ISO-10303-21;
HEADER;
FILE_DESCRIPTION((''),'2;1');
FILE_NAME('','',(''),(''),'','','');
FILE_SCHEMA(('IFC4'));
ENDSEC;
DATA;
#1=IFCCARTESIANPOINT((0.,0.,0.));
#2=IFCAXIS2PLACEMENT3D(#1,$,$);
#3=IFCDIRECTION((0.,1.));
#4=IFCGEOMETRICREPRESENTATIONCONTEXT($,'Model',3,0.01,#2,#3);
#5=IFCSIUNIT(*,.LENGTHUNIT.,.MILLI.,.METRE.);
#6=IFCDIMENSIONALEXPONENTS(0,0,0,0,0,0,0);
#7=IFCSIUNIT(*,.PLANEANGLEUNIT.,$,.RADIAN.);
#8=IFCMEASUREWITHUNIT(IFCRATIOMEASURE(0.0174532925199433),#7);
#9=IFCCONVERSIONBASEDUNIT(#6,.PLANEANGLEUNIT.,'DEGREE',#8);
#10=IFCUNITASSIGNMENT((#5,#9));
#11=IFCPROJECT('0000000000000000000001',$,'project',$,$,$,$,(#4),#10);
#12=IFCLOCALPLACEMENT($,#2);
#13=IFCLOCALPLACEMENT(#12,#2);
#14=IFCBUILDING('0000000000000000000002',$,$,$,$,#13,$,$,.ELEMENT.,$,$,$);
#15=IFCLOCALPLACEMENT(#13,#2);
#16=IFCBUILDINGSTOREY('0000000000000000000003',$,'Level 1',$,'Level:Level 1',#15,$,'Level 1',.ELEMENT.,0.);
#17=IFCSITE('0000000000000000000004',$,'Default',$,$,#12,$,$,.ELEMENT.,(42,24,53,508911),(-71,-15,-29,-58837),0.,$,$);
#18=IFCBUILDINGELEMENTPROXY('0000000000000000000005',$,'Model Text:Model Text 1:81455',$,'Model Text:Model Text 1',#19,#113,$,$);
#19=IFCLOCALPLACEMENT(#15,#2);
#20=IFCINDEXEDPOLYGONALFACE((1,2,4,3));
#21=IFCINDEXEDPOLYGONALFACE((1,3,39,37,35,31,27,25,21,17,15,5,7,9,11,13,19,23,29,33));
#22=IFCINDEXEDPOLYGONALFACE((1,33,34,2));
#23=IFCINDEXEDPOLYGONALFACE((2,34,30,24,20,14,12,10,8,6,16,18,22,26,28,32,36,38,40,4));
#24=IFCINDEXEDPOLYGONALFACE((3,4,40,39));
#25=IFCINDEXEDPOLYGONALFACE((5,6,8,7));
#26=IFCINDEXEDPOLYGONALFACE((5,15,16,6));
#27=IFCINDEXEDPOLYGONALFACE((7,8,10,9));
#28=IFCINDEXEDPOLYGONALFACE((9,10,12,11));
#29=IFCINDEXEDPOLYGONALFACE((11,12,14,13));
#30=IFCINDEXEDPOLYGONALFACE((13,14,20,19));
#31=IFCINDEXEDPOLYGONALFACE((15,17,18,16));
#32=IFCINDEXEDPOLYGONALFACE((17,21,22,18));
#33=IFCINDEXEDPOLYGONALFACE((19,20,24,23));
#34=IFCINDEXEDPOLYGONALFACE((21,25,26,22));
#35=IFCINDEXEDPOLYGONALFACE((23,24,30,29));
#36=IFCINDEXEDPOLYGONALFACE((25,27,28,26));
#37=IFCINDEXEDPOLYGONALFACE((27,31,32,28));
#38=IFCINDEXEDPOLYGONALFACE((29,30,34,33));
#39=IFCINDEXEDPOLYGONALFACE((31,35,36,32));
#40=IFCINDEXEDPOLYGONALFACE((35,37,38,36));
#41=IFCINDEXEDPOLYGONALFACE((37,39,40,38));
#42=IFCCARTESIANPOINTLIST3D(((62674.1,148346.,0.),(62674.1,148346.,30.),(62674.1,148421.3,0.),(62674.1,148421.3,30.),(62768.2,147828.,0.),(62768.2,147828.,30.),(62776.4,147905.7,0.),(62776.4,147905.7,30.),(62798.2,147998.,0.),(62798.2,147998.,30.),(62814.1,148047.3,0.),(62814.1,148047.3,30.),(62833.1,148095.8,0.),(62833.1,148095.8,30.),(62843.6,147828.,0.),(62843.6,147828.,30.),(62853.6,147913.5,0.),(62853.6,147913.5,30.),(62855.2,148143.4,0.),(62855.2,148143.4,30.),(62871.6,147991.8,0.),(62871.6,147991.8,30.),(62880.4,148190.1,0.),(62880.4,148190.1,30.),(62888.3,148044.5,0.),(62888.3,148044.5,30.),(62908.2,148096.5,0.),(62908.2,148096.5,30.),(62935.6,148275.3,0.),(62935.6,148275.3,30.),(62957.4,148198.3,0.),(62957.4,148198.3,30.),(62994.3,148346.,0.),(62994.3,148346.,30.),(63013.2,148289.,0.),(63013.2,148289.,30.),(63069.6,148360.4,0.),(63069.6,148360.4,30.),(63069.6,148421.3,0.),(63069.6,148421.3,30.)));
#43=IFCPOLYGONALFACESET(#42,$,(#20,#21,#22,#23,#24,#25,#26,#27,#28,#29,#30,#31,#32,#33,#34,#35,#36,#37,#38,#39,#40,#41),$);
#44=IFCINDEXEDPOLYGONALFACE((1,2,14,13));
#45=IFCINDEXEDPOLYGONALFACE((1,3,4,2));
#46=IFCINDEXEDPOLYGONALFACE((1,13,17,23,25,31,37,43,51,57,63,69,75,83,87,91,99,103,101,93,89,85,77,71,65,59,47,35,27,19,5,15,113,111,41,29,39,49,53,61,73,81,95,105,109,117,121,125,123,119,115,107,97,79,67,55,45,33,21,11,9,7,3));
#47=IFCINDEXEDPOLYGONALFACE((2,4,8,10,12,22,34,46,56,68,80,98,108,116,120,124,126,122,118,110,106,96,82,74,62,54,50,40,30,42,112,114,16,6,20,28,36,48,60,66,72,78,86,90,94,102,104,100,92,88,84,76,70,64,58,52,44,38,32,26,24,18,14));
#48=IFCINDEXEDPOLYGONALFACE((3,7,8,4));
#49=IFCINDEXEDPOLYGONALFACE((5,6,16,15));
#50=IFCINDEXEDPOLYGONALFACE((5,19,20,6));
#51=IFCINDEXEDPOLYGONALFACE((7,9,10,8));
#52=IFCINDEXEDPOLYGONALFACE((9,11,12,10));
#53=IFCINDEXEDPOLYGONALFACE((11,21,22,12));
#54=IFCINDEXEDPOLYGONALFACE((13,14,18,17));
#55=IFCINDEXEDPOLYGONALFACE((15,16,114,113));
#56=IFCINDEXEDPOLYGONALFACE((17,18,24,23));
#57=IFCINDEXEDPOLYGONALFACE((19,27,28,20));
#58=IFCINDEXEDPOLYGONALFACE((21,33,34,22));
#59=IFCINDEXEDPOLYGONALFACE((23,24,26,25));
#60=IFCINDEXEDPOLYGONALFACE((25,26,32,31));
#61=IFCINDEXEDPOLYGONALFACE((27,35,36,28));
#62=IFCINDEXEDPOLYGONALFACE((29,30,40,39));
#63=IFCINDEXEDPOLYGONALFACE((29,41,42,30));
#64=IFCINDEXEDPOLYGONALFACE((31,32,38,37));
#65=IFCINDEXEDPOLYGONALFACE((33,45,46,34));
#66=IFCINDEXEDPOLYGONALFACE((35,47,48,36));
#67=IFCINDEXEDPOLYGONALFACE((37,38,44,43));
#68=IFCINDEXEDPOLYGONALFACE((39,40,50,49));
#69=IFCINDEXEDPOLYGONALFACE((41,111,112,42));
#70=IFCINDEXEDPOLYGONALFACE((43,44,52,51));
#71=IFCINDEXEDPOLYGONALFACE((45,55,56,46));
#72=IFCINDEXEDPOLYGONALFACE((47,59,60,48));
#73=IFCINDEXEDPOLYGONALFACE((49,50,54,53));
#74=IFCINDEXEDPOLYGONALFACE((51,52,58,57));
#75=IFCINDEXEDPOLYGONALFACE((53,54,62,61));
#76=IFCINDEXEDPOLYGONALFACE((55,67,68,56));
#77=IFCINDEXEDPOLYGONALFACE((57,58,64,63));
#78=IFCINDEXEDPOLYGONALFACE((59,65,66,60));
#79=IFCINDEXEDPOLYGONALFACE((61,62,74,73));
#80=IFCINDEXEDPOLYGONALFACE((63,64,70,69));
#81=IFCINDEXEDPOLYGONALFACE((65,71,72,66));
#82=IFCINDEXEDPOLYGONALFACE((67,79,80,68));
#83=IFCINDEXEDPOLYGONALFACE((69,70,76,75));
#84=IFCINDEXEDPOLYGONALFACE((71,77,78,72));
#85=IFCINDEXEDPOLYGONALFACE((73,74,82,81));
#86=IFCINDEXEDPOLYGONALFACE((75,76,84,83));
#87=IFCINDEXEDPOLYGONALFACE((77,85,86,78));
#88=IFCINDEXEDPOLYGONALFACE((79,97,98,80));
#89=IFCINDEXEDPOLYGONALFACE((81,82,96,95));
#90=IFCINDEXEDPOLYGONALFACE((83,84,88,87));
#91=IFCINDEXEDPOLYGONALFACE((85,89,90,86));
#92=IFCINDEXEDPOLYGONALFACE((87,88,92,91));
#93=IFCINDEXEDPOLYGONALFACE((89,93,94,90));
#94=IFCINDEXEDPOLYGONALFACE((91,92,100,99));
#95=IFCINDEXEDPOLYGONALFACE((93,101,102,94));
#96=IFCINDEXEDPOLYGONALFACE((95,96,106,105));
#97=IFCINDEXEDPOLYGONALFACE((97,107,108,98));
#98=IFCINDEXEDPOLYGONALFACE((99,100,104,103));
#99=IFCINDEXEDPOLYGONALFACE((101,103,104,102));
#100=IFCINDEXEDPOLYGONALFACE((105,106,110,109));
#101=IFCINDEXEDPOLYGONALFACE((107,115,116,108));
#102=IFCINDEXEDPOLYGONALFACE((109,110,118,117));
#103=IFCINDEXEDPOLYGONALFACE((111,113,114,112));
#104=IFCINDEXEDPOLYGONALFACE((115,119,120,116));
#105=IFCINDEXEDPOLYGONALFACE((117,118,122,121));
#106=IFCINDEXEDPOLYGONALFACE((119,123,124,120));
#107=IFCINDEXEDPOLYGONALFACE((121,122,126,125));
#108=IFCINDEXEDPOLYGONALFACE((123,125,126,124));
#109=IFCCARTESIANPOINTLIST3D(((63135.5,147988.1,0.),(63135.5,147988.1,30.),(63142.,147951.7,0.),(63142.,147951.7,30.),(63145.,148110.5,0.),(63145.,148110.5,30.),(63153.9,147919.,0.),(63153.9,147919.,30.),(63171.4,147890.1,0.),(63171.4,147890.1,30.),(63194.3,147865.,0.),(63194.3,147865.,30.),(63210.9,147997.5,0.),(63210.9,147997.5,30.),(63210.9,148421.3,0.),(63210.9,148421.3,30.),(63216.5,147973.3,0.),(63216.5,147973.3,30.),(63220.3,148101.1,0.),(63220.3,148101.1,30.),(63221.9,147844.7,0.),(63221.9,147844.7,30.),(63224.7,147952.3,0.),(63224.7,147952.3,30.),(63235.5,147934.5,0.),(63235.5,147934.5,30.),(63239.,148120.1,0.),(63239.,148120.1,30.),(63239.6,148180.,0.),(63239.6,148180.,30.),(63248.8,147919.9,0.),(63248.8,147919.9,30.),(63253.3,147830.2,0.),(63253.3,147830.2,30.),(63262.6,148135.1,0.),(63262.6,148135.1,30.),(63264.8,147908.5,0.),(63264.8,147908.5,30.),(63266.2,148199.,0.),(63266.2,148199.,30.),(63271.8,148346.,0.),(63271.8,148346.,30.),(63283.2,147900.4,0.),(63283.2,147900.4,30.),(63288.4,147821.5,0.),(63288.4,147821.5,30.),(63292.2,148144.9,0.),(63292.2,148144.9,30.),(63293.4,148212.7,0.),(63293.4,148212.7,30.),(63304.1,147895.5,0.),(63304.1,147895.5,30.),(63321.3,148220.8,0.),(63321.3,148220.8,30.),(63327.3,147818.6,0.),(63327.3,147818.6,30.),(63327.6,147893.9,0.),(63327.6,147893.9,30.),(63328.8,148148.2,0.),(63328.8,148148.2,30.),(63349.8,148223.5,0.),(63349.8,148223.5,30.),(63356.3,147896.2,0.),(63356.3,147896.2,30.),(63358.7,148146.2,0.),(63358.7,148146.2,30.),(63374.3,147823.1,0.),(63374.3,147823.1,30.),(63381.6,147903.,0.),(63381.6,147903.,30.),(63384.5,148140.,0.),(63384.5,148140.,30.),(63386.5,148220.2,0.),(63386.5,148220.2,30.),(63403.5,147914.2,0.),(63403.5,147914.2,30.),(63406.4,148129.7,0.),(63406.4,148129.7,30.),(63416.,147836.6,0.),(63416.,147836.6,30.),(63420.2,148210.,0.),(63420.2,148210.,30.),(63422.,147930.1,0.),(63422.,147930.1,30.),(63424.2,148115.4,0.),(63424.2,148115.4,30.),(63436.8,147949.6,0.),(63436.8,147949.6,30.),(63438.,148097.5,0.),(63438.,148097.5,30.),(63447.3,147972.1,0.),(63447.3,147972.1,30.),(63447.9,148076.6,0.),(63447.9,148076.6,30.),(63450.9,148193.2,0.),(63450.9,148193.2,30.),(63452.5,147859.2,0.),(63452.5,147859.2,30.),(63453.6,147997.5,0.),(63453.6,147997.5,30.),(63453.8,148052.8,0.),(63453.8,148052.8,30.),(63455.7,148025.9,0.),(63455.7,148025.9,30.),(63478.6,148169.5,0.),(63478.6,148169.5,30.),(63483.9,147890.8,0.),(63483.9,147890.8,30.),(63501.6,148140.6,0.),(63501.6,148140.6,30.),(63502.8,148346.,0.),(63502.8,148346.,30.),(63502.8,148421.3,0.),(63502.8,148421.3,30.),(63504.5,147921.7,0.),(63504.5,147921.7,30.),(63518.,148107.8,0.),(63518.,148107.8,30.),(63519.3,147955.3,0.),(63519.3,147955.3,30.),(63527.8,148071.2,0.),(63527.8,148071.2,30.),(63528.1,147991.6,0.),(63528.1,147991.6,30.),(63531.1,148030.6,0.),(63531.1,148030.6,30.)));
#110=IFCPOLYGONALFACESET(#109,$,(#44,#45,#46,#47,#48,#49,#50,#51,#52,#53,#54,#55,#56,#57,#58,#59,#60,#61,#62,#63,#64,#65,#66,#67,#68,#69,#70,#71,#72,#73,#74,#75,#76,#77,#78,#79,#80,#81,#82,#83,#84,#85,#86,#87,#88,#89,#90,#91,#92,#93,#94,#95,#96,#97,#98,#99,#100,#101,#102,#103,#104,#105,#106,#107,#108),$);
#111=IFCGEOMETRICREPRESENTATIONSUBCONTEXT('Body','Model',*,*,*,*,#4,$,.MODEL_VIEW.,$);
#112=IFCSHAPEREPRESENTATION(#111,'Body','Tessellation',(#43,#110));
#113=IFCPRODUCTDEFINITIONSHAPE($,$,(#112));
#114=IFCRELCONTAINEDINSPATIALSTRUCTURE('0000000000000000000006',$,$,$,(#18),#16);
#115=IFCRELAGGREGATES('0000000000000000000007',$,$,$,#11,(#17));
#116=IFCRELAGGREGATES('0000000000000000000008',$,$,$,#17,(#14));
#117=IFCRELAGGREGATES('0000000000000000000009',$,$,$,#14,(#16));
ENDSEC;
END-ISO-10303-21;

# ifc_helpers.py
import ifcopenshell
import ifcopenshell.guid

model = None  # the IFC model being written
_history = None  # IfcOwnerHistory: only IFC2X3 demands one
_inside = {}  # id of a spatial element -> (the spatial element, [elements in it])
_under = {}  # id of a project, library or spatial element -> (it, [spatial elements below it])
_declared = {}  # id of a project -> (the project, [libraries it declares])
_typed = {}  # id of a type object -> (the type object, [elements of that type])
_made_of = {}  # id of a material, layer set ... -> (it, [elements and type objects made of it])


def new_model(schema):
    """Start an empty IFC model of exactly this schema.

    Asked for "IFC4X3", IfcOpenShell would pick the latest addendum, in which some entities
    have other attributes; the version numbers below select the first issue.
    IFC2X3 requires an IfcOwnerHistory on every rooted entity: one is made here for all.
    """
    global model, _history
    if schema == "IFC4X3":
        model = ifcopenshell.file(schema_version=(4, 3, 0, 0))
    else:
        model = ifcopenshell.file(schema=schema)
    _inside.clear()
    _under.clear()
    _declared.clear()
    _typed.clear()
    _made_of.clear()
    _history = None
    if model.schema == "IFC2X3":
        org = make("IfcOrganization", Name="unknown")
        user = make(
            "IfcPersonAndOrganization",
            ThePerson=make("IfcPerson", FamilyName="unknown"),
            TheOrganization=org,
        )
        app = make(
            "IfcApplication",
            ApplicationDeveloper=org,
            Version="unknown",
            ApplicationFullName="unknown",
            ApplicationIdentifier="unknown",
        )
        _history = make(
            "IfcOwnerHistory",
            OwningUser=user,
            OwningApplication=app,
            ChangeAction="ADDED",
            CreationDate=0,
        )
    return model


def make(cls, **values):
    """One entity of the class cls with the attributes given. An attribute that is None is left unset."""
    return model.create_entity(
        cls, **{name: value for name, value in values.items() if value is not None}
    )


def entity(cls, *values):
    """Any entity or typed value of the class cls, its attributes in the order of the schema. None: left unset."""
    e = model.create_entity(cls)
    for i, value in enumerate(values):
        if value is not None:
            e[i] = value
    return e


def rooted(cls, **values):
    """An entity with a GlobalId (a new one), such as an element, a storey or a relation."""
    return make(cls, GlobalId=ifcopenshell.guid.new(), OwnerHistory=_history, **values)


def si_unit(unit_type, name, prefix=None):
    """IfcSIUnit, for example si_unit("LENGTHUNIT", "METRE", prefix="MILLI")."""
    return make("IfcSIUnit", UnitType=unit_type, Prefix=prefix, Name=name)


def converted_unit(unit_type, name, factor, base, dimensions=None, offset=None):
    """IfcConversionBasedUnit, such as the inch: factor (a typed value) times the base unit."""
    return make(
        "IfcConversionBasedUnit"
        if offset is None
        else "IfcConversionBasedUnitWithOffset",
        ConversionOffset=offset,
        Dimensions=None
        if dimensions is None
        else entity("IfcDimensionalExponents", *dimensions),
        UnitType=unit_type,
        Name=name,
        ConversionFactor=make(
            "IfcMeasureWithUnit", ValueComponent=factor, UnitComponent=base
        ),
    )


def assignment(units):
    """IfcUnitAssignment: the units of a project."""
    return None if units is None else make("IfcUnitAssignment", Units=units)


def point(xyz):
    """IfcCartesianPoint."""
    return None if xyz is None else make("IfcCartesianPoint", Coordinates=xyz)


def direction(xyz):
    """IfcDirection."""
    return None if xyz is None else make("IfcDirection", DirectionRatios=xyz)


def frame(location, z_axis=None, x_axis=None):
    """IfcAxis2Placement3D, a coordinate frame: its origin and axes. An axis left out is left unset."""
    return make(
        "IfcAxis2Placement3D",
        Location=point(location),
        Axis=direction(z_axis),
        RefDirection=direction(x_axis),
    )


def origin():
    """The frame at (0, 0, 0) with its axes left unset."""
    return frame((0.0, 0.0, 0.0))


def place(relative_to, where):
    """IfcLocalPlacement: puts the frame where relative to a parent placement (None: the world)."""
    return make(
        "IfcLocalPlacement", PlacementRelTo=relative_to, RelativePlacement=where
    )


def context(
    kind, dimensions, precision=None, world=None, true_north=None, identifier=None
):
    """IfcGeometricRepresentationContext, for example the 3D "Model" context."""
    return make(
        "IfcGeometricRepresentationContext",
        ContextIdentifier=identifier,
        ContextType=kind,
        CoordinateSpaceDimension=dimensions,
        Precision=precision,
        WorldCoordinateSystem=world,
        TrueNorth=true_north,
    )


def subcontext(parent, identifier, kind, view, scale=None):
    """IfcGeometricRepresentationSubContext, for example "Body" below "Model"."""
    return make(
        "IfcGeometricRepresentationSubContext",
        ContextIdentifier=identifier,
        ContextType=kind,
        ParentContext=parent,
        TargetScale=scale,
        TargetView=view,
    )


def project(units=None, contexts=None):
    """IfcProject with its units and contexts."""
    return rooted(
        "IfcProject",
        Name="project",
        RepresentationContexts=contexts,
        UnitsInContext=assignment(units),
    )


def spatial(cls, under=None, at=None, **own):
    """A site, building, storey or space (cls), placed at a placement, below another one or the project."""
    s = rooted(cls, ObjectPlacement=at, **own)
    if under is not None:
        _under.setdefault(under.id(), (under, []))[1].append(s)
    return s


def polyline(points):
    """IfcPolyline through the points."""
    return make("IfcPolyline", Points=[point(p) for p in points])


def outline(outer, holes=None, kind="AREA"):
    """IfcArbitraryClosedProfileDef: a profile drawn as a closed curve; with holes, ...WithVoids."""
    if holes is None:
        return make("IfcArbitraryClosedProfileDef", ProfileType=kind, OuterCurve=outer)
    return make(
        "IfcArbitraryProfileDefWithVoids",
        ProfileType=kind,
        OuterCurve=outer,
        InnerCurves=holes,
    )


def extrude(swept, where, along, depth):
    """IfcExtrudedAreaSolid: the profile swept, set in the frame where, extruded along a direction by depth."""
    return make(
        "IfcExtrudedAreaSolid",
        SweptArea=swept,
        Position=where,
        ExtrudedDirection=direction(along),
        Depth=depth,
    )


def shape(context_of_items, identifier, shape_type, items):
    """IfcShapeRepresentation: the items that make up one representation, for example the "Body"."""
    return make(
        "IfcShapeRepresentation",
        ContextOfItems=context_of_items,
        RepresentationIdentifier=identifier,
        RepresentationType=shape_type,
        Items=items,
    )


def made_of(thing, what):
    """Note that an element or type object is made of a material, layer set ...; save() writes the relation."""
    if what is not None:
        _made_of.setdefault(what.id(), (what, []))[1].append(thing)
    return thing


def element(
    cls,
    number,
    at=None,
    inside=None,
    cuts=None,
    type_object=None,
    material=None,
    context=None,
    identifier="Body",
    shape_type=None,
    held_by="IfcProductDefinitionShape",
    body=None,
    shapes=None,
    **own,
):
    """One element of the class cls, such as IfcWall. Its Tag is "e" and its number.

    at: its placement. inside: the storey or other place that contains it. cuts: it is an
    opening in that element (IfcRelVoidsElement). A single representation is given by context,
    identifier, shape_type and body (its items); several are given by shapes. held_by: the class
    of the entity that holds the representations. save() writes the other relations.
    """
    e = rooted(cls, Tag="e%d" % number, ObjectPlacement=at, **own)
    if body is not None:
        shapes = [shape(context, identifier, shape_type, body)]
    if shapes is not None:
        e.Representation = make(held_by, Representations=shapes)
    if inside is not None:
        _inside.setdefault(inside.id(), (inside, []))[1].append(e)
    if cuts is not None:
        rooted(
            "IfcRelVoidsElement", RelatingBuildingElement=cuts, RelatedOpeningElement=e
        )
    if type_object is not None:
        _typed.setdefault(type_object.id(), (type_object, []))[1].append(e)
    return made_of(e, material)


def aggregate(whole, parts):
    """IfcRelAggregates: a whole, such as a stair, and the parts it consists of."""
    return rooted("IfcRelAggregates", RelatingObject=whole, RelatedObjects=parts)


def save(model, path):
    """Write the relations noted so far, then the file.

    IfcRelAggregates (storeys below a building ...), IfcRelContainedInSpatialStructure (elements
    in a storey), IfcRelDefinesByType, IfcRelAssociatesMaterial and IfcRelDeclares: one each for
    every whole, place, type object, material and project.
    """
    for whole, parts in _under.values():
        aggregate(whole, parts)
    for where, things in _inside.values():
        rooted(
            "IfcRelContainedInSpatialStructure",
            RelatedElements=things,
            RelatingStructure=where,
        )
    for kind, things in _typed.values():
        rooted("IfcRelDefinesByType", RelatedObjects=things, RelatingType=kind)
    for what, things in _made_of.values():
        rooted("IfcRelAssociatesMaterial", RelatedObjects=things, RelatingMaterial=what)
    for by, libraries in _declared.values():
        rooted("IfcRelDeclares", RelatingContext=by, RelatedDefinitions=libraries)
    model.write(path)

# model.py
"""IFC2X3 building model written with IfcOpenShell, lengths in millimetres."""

from ifc_helpers import new_model, entity, si_unit, converted_unit, direction, frame, origin, place, context, subcontext, project, spatial, polyline, outline, extrude, element, save


model = new_model("IFC2X3")

# Units and contexts
model_context = context("Model", 3, precision=0.01, world=origin(), true_north=direction((0.0, 1.0)))
body_context = subcontext(model_context, "Body", "Model", "MODEL_VIEW")
ifc_project = project(units=[si_unit("LENGTHUNIT", "METRE", prefix="MILLI"), converted_unit("PLANEANGLEUNIT", "DEGREE", entity("IfcRatioMeasure", 0.0174532925199433), si_unit("PLANEANGLEUNIT", "RADIAN"), dimensions=[0, 0, 0, 0, 0, 0, 0])], contexts=[model_context])

# Site, building, storey
site_placement = place(None, origin())
site = spatial("IfcSite", under=ifc_project, at=site_placement, Name="Default", CompositionType="ELEMENT", RefLatitude=(42, 24, 53, 508911), RefLongitude=(-71, -15, -29, -58837), RefElevation=0.0)
building_placement = place(site_placement, origin())
building = spatial("IfcBuilding", under=site, at=building_placement, CompositionType="ELEMENT")
storey_placement = place(building_placement, origin())
storey = spatial("IfcBuildingStorey", under=building, at=storey_placement, Name="Level 1", ObjectType="Level:Level 1", LongName="Level 1", CompositionType="ELEMENT", Elevation=0.0)

# Building element proxy
proxy_1_placement = place(storey_placement, origin())
element("IfcBuildingElementProxy", 1, at=proxy_1_placement, inside=storey, Name="Model Text:Model Text 1:81455", ObjectType="Model Text:Model Text 1", context=body_context, shape_type="SweptSolid", body=[
    extrude(outline(polyline([(-199.9, -209.0), (-199.9, -284.3), (195.7, -284.3), (195.7, -223.4), (139.3, -152.0), (83.5, -61.3), (34.2, 40.5), (14.4, 92.5), (-2.4, 145.2), (-20.3, 223.5), (-30.3, 309.0), (-105.7, 309.0), (-97.5, 231.3), (-75.7, 139.0), (-59.9, 89.7), (-40.9, 41.2), (-18.8, -6.4), (6.4, -53.1), (61.7, -138.3), (120.3, -209.0), (-199.9, -209.0)])), frame((62873.9, 148137.0, 0.0), z_axis=(0.0, 0.0, -1.0), x_axis=(1.0, 0.0, 0.0)), (0.0, 0.0, -1.0), 30.0),
    extrude(outline(polyline([(12.1, -219.3), (49.1, -219.3), (83.4, -213.2), (114.8, -201.1), (143.5, -182.8), (168.3, -159.2), (188.1, -130.8), (202.8, -97.8), (212.4, -60.0), (216.1, -12.9), (210.0, 30.5), (194.1, 70.4), (168.4, 106.8), (141.6, 132.5), (111.1, 152.9), (76.9, 167.9), (39.0, 177.6), (-1.5, 181.4), (-39.3, 178.1), (-74.4, 167.6), (-106.9, 150.1), (-135.0, 126.9), (-157.0, 99.6), (-172.8, 68.1), (-182.5, 32.6), (-184.8, 4.0), (-181.6, -24.8), (-172.9, -54.0), (-158.8, -83.5), (-316.6, -22.9), (-276.5, 204.6), (-350.7, 217.7), (-401.4, -69.8), (-106.8, -188.8), (-84.5, -116.2), (-99.9, -94.5), (-110.6, -68.6), (-115.1, -37.8), (-112.0, -1.2), (-104.8, 27.9), (-94.2, 52.3), (-80.3, 72.0), (-63.1, 87.0), (-43.0, 97.5), (-20.8, 103.6), (3.8, 105.3), (30.5, 102.6), (58.1, 95.6), (82.1, 84.9), (102.4, 70.6), (119.1, 52.7), (131.4, 31.7), (138.7, 8.2), (141.0, -17.9), (138.2, -46.6), (132.6, -69.4), (124.1, -89.2), (112.9, -105.9), (99.0, -119.6), (82.3, -130.2), (62.9, -137.7), (40.8, -142.2), (15.9, -143.5), (12.1, -219.3)])), frame((63349.4, 148038.2, 0.0), z_axis=(0.0, 0.0, 1.0), x_axis=(0.173842, -0.984774, 0.0)), (0.0, 0.0, 1.0), 30.0),
])

save(model, "model.ifc")
